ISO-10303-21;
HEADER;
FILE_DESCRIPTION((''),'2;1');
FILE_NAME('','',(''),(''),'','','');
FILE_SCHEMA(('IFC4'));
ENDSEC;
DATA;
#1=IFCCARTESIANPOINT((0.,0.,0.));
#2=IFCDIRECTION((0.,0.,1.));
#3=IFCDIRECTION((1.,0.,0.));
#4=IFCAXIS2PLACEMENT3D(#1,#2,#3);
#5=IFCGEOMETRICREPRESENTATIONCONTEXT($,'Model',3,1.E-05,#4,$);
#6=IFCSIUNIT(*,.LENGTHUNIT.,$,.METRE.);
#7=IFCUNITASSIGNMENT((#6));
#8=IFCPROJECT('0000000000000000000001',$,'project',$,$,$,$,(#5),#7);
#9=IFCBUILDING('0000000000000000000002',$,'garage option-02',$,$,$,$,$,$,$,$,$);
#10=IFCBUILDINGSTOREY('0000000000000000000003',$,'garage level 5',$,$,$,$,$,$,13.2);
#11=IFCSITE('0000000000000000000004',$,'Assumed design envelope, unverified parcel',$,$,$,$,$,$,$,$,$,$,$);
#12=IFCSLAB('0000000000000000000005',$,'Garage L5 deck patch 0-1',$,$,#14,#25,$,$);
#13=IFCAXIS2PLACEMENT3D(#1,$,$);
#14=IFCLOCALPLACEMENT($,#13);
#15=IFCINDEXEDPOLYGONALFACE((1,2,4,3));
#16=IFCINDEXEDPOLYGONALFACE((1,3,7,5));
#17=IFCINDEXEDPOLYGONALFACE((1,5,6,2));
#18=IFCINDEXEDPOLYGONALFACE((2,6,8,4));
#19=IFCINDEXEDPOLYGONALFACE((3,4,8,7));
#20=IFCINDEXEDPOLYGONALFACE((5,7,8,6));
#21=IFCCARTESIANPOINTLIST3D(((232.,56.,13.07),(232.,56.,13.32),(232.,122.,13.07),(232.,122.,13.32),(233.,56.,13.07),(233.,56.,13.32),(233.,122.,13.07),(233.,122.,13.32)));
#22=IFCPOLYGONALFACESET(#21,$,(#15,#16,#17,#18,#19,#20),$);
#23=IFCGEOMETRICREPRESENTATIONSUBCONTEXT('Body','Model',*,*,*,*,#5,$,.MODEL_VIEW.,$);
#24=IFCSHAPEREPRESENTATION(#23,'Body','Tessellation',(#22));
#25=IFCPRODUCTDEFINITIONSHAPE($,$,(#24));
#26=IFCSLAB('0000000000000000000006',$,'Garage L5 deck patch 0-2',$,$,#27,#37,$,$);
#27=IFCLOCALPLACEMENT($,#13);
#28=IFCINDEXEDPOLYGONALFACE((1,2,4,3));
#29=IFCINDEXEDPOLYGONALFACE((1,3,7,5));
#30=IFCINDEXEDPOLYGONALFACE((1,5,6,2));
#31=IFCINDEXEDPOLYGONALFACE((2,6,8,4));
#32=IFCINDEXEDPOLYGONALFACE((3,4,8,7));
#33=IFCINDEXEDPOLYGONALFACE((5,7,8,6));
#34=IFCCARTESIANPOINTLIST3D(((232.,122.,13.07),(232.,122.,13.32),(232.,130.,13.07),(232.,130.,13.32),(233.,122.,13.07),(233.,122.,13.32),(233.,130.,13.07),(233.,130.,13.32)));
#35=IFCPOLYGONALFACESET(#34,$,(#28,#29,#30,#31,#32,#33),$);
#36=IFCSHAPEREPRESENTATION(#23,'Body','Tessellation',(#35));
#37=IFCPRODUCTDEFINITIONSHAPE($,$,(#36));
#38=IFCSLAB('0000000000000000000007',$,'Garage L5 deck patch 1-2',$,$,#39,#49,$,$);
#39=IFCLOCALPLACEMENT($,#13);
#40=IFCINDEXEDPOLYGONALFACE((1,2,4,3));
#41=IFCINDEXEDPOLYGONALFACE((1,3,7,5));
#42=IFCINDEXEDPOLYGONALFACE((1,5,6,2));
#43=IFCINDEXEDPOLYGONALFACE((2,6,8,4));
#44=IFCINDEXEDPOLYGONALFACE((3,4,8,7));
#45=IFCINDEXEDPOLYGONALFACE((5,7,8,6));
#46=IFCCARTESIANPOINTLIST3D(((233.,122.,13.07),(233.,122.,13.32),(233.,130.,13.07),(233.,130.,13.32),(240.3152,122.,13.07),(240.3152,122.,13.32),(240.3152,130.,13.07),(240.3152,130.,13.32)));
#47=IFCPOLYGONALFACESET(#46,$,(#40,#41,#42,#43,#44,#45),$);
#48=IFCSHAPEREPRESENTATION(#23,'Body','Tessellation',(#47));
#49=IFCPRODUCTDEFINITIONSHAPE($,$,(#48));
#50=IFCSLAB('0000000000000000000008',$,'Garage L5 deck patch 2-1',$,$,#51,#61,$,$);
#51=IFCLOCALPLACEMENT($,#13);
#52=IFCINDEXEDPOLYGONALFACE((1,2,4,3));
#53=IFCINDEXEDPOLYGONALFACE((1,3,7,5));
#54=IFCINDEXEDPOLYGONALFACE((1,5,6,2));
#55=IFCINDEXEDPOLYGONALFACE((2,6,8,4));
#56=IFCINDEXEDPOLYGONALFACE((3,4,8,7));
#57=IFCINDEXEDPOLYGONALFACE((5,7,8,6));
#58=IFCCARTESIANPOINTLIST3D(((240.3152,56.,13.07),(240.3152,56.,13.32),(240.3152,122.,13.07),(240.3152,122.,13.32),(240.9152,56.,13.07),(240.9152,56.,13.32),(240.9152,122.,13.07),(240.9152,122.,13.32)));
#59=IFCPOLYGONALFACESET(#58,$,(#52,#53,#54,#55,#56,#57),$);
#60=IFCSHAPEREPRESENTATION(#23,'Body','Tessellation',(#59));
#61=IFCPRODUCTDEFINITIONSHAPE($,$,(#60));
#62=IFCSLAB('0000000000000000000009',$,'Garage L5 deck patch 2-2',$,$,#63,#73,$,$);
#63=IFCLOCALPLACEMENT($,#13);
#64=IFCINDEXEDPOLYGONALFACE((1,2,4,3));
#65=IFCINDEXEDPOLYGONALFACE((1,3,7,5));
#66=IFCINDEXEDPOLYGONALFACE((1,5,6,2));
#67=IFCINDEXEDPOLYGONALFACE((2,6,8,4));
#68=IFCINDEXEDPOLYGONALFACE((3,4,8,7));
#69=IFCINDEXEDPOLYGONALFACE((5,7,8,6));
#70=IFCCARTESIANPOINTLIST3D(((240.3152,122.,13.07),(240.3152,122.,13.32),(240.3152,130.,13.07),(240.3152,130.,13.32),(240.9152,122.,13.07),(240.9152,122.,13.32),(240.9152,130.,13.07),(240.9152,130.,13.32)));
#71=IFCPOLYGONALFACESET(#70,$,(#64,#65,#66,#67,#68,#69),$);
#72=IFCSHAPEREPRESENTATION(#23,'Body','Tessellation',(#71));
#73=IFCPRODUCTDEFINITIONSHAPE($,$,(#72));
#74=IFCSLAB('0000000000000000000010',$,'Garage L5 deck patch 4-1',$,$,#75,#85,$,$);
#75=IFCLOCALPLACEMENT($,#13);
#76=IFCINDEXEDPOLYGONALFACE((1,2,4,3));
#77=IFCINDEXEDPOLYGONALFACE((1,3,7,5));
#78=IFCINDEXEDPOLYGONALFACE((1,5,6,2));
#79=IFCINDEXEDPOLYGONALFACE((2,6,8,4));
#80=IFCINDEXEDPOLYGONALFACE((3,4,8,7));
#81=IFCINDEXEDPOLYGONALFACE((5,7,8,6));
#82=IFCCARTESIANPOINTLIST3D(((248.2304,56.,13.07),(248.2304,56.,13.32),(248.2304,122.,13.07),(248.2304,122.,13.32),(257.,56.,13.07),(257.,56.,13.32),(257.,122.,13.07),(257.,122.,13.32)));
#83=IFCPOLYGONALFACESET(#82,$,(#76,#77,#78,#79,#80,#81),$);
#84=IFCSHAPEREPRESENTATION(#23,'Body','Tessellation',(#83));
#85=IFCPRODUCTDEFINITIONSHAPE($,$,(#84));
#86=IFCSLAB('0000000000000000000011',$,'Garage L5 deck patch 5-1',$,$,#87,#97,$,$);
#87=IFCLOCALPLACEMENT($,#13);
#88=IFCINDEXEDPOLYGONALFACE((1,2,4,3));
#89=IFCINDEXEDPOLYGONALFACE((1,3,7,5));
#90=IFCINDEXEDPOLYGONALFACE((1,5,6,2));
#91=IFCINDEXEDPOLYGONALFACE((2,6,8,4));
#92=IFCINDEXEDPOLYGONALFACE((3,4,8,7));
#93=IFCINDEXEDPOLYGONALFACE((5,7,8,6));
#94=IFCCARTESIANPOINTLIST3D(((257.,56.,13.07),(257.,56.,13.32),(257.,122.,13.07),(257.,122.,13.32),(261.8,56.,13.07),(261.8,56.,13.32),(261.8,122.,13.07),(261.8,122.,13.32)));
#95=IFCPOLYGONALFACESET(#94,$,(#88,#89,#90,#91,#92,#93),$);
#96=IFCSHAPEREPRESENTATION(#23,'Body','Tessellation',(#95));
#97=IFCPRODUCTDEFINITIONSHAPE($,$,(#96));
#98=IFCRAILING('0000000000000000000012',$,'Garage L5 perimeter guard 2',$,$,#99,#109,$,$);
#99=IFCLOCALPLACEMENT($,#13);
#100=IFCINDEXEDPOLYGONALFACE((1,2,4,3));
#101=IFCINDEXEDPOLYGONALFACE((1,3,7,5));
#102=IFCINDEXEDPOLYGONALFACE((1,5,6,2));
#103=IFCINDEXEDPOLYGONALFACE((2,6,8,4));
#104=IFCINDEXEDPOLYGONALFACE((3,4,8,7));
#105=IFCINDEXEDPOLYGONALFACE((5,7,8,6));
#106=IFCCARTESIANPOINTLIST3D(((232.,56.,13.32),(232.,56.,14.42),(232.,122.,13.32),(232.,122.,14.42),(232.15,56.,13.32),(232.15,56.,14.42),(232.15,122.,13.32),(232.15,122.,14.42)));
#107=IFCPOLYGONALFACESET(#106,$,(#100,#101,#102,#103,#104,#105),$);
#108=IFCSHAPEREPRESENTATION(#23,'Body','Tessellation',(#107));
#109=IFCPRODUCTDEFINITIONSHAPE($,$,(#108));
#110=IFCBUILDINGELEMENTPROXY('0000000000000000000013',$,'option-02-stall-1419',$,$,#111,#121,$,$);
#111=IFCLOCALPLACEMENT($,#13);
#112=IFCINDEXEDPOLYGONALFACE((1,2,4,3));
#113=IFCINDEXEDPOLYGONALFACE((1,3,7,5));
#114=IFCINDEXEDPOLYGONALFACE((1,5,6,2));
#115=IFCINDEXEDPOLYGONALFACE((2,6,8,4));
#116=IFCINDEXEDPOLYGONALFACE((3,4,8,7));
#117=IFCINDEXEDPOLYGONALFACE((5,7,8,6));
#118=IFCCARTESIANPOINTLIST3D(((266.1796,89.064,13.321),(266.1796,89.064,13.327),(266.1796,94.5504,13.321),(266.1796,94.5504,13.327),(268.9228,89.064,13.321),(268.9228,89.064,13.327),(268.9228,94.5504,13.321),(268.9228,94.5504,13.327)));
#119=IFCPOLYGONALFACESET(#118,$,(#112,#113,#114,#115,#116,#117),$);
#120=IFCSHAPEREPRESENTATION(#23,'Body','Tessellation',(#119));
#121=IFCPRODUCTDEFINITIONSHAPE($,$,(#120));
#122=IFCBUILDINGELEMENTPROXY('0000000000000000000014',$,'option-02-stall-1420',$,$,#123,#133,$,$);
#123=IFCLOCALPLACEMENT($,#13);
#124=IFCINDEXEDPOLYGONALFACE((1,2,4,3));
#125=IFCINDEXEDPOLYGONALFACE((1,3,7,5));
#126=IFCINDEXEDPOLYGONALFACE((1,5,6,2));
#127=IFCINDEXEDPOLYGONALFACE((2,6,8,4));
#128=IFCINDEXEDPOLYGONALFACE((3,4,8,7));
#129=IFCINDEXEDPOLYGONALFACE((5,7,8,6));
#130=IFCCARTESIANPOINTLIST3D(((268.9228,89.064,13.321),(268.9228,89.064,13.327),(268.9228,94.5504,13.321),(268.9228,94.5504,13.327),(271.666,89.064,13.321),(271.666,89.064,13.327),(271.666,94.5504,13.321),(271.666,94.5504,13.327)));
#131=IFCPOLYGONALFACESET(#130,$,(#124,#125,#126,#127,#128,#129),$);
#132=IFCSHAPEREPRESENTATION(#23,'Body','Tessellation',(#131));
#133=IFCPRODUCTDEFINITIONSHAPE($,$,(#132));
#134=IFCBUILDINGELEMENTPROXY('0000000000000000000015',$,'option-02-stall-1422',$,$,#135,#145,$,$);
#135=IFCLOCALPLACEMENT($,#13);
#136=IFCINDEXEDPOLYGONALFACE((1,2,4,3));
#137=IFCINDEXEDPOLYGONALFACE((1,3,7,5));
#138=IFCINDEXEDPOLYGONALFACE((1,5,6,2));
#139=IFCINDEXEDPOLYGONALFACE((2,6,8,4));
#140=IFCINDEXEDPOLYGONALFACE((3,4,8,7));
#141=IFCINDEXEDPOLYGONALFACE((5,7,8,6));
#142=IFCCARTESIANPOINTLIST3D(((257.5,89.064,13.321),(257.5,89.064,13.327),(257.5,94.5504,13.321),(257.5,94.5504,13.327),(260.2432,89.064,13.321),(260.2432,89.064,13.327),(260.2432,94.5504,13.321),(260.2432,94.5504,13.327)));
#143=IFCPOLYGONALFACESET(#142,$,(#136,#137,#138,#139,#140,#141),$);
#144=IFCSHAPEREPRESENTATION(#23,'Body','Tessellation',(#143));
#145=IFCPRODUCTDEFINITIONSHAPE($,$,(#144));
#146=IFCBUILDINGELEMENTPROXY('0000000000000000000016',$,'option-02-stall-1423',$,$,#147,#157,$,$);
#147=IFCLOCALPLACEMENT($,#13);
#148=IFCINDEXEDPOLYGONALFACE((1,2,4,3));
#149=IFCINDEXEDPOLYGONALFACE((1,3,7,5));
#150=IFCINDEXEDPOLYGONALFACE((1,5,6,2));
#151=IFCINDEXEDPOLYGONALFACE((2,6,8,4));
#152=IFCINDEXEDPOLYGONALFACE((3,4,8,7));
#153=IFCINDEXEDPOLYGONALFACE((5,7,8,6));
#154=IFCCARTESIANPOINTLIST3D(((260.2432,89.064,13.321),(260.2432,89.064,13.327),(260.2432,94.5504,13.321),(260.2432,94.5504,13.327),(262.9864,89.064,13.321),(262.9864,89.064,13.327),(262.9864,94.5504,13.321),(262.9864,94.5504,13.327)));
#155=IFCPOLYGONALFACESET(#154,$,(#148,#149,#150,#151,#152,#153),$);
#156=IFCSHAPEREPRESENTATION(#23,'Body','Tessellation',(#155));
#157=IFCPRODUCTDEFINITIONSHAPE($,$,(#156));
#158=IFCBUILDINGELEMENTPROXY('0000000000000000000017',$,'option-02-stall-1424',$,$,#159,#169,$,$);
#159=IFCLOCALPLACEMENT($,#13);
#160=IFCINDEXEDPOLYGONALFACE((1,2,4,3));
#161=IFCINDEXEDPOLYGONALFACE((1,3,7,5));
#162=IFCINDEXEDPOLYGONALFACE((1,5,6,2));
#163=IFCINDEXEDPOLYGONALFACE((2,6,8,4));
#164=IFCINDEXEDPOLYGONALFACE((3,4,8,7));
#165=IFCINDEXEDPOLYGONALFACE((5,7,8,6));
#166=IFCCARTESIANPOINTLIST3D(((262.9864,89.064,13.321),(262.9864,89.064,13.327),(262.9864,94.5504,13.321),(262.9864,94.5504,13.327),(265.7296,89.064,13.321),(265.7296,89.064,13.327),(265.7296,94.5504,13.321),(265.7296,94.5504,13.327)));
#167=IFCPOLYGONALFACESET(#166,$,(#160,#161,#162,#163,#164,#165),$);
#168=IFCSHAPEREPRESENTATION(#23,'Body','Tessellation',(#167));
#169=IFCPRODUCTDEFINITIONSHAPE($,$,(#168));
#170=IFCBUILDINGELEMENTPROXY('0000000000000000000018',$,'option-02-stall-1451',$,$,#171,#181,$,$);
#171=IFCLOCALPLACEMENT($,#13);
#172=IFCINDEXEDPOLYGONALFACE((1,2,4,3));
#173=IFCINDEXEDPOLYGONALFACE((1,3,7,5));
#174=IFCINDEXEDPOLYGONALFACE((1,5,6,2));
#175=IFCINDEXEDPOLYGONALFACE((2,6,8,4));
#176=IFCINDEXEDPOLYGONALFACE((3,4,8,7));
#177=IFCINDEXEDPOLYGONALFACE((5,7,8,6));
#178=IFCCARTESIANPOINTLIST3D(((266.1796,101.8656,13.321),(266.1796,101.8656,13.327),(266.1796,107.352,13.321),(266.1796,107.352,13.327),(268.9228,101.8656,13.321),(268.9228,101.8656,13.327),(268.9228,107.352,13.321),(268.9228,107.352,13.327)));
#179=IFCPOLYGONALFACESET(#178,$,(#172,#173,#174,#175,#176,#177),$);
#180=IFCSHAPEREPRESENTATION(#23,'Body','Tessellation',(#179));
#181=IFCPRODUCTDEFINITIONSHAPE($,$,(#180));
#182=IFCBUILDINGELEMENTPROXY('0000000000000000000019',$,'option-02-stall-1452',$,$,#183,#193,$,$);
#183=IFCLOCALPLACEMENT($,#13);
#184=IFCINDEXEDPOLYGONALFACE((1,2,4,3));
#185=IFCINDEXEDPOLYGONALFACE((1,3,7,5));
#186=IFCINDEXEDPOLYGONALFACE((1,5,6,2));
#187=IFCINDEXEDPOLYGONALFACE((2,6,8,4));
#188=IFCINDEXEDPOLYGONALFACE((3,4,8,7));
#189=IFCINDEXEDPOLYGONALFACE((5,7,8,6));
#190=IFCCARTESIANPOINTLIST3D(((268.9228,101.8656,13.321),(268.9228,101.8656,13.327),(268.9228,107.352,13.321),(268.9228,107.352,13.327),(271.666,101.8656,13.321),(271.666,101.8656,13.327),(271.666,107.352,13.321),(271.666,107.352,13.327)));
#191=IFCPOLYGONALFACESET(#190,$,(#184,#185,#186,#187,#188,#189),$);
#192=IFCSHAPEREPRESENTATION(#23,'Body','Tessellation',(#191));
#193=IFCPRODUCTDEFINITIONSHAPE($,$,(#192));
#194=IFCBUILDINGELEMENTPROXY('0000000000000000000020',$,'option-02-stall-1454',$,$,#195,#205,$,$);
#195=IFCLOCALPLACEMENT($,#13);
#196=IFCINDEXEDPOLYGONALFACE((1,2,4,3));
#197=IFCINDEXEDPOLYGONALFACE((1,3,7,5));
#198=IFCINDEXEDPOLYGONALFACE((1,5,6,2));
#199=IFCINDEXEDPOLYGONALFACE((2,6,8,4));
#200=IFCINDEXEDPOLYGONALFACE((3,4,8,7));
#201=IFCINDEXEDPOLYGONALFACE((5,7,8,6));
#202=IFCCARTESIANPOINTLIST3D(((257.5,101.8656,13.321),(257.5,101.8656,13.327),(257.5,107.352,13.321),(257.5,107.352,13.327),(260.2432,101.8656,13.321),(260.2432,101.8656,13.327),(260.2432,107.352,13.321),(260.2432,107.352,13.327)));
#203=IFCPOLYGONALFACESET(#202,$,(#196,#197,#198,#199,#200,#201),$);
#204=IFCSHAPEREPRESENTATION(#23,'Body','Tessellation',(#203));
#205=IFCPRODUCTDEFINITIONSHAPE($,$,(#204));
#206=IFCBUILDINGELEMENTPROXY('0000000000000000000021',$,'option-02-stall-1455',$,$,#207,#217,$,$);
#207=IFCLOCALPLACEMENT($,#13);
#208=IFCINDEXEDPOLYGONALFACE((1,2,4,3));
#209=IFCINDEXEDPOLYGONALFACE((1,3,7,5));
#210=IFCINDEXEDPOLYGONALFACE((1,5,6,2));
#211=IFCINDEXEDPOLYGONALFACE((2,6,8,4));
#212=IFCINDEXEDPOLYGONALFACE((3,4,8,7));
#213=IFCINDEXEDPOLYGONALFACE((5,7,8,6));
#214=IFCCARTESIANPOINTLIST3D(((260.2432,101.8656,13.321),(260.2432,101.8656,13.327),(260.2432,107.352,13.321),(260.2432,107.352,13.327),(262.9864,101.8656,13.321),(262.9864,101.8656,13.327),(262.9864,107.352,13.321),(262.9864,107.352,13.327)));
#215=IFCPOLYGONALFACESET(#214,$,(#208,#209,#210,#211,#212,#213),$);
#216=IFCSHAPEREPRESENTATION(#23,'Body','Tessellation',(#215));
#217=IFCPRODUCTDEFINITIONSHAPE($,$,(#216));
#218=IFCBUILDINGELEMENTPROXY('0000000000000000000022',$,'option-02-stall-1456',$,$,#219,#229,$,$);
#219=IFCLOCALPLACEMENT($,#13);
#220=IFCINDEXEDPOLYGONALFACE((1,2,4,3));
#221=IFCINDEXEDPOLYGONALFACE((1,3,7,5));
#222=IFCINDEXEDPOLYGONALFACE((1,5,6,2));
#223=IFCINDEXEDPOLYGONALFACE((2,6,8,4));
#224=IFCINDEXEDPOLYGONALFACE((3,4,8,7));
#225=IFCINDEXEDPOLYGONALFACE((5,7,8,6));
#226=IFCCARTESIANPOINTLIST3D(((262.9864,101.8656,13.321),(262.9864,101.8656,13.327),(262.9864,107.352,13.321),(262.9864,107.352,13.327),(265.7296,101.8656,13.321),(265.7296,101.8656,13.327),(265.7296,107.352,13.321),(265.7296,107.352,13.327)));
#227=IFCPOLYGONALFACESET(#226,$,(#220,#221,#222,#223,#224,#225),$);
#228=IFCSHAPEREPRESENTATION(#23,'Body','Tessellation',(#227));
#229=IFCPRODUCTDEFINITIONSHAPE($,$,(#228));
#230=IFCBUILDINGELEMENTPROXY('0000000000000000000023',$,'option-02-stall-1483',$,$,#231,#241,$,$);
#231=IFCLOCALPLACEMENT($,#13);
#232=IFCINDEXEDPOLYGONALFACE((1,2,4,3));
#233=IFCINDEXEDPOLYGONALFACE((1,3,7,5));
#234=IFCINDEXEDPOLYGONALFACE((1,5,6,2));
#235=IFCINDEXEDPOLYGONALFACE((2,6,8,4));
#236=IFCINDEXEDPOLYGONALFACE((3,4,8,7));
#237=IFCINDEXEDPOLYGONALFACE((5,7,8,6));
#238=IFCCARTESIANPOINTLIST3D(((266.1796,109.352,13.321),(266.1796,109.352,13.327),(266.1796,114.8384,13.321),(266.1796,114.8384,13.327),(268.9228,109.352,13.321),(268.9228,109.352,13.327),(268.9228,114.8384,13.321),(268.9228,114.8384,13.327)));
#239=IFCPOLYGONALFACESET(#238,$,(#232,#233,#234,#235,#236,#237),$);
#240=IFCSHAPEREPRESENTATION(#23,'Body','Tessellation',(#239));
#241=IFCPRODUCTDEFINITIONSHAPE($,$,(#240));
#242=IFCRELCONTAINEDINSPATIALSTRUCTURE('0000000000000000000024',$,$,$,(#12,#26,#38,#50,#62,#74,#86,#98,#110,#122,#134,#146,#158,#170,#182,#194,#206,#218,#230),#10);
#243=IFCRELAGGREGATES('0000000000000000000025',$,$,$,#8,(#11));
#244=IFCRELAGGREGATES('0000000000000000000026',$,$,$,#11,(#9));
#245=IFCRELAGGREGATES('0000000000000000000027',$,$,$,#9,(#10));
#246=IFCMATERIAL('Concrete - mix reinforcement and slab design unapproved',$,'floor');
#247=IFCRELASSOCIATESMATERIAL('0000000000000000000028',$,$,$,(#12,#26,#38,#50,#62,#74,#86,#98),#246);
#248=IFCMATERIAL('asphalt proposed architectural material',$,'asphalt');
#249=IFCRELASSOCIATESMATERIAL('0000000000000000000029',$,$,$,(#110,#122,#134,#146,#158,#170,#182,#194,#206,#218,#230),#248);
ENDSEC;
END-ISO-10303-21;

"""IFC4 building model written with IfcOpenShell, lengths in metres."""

from ifc_helpers import new_model, si_unit, frame, origin_with_axes, place, context, subcontext, project, spatial, rectangle, extrude, material, element, save


model = new_model("IFC4")

# Units and contexts
model_context = context("Model", 3, precision=1e-05, world=origin_with_axes())
body_context = subcontext(model_context, "Body", "Model", "MODEL_VIEW")
ifc_project = project(units=[si_unit("LENGTHUNIT", "METRE")], contexts=[model_context])

# Site, building, storey
site = spatial("IfcSite", under=ifc_project, Name="Assumed design envelope, unverified parcel")
building = spatial("IfcBuilding", under=site, Name="garage option-02")
storey = spatial("IfcBuildingStorey", under=building, Name="garage level 5", Elevation=13.2)

# Slabs
ifc_material_1 = material(Name="Concrete - mix reinforcement and slab design unapproved", Category="floor")
slab_1_placement = place(None, frame((232.5, 89.0, 13.07), z_axis=(0.0, 0.0, 1.0), x_axis=(1.0, 0.0, 0.0)))
element("IfcSlab", 1, at=slab_1_placement, inside=storey, material=ifc_material_1, Name="Garage L5 deck patch 0-1", context=body_context, shape_type="SweptSolid", body=[
    extrude(rectangle(XDim=1.0, YDim=66.0), origin_with_axes(), (0.0, 0.0, 1.0), 0.25),
])
slab_2_placement = place(None, frame((232.5, 126.0, 13.07), z_axis=(0.0, 0.0, 1.0), x_axis=(1.0, 0.0, 0.0)))
element("IfcSlab", 2, at=slab_2_placement, inside=storey, material=ifc_material_1, Name="Garage L5 deck patch 0-2", context=body_context, shape_type="SweptSolid", body=[
    extrude(rectangle(XDim=1.0, YDim=8.0), origin_with_axes(), (0.0, 0.0, 1.0), 0.25),
])
slab_3_placement = place(None, frame((236.6576, 126.0, 13.07), z_axis=(0.0, 0.0, 1.0), x_axis=(1.0, 0.0, 0.0)))
element("IfcSlab", 3, at=slab_3_placement, inside=storey, material=ifc_material_1, Name="Garage L5 deck patch 1-2", context=body_context, shape_type="SweptSolid", body=[
    extrude(rectangle(XDim=7.3152, YDim=8.0), origin_with_axes(), (0.0, 0.0, 1.0), 0.25),
])
slab_4_placement = place(None, frame((240.6152, 89.0, 13.07), z_axis=(0.0, 0.0, 1.0), x_axis=(1.0, 0.0, 0.0)))
element("IfcSlab", 4, at=slab_4_placement, inside=storey, material=ifc_material_1, Name="Garage L5 deck patch 2-1", context=body_context, shape_type="SweptSolid", body=[
    extrude(rectangle(XDim=0.6, YDim=66.0), origin_with_axes(), (0.0, 0.0, 1.0), 0.25),
])
slab_5_placement = place(None, frame((240.6152, 126.0, 13.07), z_axis=(0.0, 0.0, 1.0), x_axis=(1.0, 0.0, 0.0)))
element("IfcSlab", 5, at=slab_5_placement, inside=storey, material=ifc_material_1, Name="Garage L5 deck patch 2-2", context=body_context, shape_type="SweptSolid", body=[
    extrude(rectangle(XDim=0.6, YDim=8.0), origin_with_axes(), (0.0, 0.0, 1.0), 0.25),
])
slab_6_placement = place(None, frame((252.6152, 89.0, 13.07), z_axis=(0.0, 0.0, 1.0), x_axis=(1.0, 0.0, 0.0)))
element("IfcSlab", 6, at=slab_6_placement, inside=storey, material=ifc_material_1, Name="Garage L5 deck patch 4-1", context=body_context, shape_type="SweptSolid", body=[
    extrude(rectangle(XDim=8.7696, YDim=66.0), origin_with_axes(), (0.0, 0.0, 1.0), 0.25),
])
slab_7_placement = place(None, frame((259.4, 89.0, 13.07), z_axis=(0.0, 0.0, 1.0), x_axis=(1.0, 0.0, 0.0)))
element("IfcSlab", 7, at=slab_7_placement, inside=storey, material=ifc_material_1, Name="Garage L5 deck patch 5-1", context=body_context, shape_type="SweptSolid", body=[
    extrude(rectangle(XDim=4.8, YDim=66.0), origin_with_axes(), (0.0, 0.0, 1.0), 0.25),
])

# Railing
railing_placement = place(None, frame((232.075, 89.0, 13.32), z_axis=(0.0, 0.0, 1.0), x_axis=(1.0, 0.0, 0.0)))
element("IfcRailing", 8, at=railing_placement, inside=storey, material=ifc_material_1, Name="Garage L5 perimeter guard 2", context=body_context, shape_type="SweptSolid", body=[
    extrude(rectangle(XDim=0.15, YDim=66.0), origin_with_axes(), (0.0, 0.0, 1.0), 1.1),
])

# Building element proxies
ifc_material_2 = material(Name="asphalt proposed architectural material", Category="asphalt")
for number, where, z_axis, x_axis, name in (
    (9, (267.5512, 91.8072, 13.321), (0.0, 0.0, 1.0), (1.0, 0.0, 0.0), "option-02-stall-1419"),
    (10, (270.2944, 91.8072, 13.321), (0.0, 0.0, 1.0), (1.0, 0.0, 0.0), "option-02-stall-1420"),
    (11, (258.8716, 91.8072, 13.321), (0.0, 0.0, 1.0), (1.0, 0.0, 0.0), "option-02-stall-1422"),
    (12, (261.6148, 91.8072, 13.321), (0.0, 0.0, 1.0), (1.0, 0.0, 0.0), "option-02-stall-1423"),
    (13, (264.358, 91.8072, 13.321), (0.0, 0.0, 1.0), (1.0, 0.0, 0.0), "option-02-stall-1424"),
    (14, (267.5512, 104.6088, 13.321), (0.0, 0.0, 1.0), (1.0, 0.0, 0.0), "option-02-stall-1451"),
    (15, (270.2944, 104.6088, 13.321), (0.0, 0.0, 1.0), (1.0, 0.0, 0.0), "option-02-stall-1452"),
    (16, (258.8716, 104.6088, 13.321), (0.0, 0.0, 1.0), (1.0, 0.0, 0.0), "option-02-stall-1454"),
    (17, (261.6148, 104.6088, 13.321), (0.0, 0.0, 1.0), (1.0, 0.0, 0.0), "option-02-stall-1455"),
    (18, (264.358, 104.6088, 13.321), (0.0, 0.0, 1.0), (1.0, 0.0, 0.0), "option-02-stall-1456"),
    (19, (267.5512, 112.0952, 13.321), (0.0, 0.0, 1.0), (1.0, 0.0, 0.0), "option-02-stall-1483"),
):
    element("IfcBuildingElementProxy", number, at=place(None, frame(where, z_axis=z_axis, x_axis=x_axis)), inside=storey, material=ifc_material_2, Name=name, context=body_context, shape_type="SweptSolid", body=[
        extrude(rectangle(XDim=2.7432, YDim=5.4864), origin_with_axes(), (0.0, 0.0, 1.0), 0.006),
    ])

save(model, "model.ifc")
